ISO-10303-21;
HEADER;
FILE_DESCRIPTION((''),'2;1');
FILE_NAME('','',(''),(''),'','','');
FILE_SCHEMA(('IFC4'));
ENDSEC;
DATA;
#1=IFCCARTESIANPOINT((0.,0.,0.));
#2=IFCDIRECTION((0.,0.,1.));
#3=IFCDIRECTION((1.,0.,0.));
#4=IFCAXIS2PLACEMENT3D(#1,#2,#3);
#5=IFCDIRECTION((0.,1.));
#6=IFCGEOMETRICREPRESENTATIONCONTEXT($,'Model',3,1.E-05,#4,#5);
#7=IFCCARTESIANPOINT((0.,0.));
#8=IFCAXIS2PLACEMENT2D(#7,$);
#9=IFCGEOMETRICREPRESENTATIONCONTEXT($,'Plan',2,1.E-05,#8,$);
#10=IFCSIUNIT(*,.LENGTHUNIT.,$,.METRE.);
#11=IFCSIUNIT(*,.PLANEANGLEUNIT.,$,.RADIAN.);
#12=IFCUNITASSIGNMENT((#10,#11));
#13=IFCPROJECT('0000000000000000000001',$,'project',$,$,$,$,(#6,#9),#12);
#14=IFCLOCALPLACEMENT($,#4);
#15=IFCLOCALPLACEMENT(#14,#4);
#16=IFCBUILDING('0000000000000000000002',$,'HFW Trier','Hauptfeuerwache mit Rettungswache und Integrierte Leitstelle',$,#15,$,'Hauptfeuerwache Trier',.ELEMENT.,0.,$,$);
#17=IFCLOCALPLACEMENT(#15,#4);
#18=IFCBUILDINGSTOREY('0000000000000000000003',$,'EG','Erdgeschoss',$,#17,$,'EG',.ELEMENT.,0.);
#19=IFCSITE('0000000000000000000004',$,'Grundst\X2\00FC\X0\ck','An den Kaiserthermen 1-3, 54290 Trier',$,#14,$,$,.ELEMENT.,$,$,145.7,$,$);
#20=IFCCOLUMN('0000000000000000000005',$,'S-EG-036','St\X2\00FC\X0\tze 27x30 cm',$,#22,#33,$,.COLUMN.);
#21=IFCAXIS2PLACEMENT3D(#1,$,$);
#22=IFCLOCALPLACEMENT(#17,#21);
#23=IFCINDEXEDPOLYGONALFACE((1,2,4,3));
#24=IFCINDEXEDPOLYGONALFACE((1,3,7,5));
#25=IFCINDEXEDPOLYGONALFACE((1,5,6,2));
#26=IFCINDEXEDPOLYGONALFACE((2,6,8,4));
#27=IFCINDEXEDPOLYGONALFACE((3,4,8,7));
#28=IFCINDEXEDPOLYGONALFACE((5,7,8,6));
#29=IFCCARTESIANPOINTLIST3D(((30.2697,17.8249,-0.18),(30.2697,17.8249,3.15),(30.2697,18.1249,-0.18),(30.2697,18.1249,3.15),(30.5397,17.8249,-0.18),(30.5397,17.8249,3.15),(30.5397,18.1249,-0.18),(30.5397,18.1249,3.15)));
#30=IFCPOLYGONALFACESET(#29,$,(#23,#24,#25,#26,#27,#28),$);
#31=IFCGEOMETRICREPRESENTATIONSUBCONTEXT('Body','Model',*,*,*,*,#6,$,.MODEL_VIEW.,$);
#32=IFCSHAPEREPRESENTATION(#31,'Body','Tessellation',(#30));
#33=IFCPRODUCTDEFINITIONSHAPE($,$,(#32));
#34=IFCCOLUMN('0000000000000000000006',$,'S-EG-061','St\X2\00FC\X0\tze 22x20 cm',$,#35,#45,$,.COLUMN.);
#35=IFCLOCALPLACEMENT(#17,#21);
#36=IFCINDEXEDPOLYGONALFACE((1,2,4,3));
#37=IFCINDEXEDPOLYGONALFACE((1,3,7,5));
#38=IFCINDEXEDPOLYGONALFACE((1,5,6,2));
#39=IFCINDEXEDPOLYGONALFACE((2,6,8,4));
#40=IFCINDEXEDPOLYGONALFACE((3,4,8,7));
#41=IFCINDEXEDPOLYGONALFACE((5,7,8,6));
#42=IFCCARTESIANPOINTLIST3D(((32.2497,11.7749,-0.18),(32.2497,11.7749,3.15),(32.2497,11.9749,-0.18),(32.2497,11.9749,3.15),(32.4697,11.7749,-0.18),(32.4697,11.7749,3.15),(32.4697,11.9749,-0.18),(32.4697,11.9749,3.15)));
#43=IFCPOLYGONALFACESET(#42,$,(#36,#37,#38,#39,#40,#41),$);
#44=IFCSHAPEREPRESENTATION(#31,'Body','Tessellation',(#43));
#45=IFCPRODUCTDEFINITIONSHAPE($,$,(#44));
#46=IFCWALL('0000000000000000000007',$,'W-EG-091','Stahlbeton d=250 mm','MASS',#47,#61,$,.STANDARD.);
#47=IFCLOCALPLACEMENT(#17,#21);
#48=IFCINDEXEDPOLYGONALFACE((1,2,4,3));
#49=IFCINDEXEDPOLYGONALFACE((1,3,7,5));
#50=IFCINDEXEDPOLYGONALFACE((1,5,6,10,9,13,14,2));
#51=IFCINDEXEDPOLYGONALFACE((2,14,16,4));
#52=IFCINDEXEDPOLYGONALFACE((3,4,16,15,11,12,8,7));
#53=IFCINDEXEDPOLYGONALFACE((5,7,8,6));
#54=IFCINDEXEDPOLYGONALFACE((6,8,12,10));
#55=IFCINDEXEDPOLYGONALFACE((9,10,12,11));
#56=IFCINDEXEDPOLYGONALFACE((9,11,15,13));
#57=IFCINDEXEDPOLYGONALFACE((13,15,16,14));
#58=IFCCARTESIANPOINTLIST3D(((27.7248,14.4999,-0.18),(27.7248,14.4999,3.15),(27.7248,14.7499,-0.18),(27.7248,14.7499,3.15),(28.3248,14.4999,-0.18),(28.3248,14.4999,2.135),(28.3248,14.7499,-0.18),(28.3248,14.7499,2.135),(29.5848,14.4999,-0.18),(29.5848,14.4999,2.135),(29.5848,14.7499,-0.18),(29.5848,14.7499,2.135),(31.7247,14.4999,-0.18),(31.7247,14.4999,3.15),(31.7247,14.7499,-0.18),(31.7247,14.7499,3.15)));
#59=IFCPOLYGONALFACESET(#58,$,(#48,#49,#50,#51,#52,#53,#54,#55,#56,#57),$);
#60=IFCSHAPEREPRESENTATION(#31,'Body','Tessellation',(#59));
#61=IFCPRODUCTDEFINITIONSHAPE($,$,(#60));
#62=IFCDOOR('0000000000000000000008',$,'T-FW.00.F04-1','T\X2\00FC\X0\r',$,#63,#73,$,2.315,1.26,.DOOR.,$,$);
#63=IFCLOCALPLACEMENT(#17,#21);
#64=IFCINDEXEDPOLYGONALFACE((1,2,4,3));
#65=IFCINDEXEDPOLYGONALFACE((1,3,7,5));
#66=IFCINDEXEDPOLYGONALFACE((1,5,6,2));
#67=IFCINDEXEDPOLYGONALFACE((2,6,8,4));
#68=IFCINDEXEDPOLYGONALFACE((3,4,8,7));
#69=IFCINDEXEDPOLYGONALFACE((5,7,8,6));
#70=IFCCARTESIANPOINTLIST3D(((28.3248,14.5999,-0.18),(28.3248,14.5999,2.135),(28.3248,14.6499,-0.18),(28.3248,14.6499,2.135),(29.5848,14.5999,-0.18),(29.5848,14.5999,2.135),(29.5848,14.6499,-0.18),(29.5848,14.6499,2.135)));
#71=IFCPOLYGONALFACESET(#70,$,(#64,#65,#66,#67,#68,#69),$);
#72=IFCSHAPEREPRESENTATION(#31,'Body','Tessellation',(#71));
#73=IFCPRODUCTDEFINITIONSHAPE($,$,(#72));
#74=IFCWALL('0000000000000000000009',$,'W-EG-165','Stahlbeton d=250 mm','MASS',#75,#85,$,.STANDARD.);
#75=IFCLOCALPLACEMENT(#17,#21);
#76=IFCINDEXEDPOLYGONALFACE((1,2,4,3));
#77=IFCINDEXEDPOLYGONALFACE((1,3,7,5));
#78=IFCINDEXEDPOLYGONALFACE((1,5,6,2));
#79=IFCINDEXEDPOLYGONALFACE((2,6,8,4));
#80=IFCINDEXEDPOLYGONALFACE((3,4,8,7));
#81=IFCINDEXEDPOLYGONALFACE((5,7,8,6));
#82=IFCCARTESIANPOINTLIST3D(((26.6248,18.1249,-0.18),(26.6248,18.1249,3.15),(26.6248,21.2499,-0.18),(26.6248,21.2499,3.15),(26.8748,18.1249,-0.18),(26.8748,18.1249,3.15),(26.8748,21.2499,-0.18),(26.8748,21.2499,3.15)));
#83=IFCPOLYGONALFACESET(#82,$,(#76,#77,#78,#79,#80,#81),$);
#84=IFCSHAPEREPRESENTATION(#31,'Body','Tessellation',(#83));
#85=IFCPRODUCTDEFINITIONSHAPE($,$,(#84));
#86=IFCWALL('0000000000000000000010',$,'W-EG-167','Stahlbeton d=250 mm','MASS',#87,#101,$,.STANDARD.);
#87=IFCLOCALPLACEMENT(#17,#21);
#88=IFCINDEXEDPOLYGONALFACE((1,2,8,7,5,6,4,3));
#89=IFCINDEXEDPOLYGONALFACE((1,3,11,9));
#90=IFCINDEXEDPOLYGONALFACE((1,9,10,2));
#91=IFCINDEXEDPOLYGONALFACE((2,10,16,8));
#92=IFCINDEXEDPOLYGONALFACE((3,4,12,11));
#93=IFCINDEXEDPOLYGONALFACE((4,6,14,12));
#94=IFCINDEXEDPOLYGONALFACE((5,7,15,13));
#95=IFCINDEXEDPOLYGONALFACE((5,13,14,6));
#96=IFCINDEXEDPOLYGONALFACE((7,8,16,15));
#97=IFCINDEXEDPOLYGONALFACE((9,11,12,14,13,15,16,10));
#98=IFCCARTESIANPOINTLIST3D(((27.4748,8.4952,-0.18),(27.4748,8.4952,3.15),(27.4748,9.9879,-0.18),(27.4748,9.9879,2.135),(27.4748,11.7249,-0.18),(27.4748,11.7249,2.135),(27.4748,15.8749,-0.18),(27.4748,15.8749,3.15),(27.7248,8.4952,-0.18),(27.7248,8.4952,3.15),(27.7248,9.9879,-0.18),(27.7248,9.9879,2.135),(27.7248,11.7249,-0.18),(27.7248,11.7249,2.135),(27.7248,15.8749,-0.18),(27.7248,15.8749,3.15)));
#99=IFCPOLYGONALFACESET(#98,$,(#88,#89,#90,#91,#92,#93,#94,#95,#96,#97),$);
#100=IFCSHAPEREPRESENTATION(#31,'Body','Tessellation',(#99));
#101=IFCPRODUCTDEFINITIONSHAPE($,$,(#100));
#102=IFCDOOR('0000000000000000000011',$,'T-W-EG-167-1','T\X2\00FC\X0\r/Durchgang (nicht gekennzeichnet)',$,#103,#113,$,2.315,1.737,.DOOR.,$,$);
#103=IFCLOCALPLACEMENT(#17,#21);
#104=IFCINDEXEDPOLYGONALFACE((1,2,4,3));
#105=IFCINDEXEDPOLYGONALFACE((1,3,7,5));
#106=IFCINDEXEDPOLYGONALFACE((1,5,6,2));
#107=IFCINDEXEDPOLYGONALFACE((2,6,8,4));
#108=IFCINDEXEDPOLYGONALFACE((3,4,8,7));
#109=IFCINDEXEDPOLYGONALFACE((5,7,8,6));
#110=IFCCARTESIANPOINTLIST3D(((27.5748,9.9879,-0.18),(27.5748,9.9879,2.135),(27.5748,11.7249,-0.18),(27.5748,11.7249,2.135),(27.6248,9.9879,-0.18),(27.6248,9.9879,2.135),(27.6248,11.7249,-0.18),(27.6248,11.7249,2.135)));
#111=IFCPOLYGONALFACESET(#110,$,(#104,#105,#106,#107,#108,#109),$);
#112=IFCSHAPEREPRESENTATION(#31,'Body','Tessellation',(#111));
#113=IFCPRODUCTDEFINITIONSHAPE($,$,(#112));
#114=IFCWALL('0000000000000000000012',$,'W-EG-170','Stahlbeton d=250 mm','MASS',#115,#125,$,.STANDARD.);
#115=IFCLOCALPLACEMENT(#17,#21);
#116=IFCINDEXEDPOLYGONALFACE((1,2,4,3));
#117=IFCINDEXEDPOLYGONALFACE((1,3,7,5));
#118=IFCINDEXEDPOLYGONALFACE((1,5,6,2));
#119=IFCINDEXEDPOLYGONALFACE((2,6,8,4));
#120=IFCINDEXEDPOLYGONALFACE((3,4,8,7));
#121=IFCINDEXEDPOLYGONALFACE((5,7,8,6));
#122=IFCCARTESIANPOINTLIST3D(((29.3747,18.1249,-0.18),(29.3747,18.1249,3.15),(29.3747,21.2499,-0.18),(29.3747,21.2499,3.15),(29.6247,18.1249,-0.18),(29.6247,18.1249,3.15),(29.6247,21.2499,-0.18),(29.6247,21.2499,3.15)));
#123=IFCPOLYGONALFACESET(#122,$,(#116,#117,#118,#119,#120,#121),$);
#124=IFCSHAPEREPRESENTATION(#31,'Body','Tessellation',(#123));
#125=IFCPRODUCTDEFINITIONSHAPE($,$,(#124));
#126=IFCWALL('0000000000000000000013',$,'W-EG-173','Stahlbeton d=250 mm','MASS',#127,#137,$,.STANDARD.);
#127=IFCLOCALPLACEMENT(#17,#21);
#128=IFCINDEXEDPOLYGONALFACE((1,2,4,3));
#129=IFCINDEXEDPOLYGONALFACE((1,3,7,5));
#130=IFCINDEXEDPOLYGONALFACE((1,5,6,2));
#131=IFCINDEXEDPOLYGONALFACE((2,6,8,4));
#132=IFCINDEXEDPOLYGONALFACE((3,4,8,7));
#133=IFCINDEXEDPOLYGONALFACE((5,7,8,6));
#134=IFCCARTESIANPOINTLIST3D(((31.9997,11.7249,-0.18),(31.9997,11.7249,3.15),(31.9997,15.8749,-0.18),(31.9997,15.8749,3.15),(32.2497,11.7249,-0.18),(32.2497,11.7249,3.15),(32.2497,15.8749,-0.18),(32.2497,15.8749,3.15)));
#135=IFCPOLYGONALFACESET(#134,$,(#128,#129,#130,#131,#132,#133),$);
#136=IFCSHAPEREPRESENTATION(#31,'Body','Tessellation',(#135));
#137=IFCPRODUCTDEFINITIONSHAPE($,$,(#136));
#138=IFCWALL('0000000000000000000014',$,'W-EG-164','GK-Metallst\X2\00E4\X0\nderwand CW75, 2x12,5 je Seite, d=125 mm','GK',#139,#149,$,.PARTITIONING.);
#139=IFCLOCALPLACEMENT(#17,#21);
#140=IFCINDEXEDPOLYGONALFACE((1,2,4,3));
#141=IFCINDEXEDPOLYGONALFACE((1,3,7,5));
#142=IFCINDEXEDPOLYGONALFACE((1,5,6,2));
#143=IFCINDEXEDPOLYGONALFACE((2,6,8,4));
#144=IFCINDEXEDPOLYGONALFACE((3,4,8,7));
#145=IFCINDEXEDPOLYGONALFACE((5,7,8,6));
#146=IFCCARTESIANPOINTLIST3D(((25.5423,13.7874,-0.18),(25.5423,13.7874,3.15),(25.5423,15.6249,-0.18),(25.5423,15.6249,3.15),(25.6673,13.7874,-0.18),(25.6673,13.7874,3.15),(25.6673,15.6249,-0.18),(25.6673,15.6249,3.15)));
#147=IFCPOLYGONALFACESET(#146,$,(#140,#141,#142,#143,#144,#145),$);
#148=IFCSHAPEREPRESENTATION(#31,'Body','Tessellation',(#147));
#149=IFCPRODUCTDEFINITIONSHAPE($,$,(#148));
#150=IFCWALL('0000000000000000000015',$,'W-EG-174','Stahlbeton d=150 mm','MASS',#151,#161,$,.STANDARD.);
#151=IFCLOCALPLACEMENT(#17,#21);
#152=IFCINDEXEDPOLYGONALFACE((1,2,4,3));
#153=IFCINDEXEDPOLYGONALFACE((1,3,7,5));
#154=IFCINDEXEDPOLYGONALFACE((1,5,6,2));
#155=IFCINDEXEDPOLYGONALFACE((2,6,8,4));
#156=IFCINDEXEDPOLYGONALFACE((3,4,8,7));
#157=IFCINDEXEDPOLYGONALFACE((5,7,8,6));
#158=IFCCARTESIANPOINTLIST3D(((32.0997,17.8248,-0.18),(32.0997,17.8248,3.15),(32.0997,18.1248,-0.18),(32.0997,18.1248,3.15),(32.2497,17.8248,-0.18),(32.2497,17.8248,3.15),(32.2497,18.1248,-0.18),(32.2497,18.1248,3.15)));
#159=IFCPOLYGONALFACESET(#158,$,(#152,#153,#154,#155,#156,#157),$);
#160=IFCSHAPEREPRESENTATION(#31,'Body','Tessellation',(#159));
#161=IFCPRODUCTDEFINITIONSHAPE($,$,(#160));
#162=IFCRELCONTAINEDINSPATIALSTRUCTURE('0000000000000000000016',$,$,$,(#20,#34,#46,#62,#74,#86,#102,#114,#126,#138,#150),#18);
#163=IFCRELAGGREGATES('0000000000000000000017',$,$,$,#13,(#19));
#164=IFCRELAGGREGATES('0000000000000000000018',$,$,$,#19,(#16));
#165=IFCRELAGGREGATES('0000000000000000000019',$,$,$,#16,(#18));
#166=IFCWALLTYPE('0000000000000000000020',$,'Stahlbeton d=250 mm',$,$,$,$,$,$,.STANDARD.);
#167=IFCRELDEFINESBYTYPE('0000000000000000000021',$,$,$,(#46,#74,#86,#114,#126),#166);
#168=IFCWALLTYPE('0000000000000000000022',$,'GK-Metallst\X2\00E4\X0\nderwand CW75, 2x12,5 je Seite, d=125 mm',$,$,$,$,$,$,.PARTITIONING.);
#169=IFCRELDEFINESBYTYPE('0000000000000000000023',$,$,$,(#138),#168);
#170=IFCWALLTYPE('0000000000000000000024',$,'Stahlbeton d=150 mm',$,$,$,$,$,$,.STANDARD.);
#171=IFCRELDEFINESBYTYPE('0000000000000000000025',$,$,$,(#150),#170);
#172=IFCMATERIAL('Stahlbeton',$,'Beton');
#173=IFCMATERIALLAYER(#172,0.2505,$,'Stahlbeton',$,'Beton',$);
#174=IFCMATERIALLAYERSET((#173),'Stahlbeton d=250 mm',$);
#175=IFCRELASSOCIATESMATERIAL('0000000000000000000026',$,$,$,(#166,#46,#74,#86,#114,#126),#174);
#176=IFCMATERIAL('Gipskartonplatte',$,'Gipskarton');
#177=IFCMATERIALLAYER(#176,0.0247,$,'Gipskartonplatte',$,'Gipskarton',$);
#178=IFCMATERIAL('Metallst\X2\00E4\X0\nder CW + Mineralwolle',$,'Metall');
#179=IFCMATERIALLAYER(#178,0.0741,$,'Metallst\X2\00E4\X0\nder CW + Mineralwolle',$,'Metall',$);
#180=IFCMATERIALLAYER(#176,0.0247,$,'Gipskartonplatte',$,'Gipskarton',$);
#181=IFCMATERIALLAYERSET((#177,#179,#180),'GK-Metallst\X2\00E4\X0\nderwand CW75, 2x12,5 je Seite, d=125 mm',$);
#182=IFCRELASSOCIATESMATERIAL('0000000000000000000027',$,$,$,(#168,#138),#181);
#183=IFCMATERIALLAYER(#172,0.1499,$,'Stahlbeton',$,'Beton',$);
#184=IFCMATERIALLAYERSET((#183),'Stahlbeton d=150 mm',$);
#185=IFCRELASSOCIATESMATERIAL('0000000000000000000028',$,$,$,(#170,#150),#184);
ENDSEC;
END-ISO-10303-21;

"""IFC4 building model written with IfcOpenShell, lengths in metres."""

from ifc_helpers import new_model, si_unit, direction, frame, frame_2d, origin_with_axes, origin_2d, place, context, subcontext, project, spatial, rectangle, extrude, material, layer, layer_set, layer_usage, type_object, element, fill, save


model = new_model("IFC4")

# Units and contexts
model_context = context("Model", 3, precision=1e-05, world=origin_with_axes(), true_north=direction((0.0, 1.0)))
plan_context = context("Plan", 2, precision=1e-05, world=origin_2d())
body_context = subcontext(model_context, "Body", "Model", "MODEL_VIEW")
ifc_project = project(units=[si_unit("LENGTHUNIT", "METRE"), si_unit("PLANEANGLEUNIT", "RADIAN")], contexts=[model_context, plan_context])

# Site, building, storey
site_placement = place(None, origin_with_axes())
site = spatial("IfcSite", under=ifc_project, at=site_placement, Name="Grundstück", Description="An den Kaiserthermen 1-3, 54290 Trier", CompositionType="ELEMENT", RefElevation=145.7)
building_placement = place(site_placement, origin_with_axes())
building = spatial("IfcBuilding", under=site, at=building_placement, Name="HFW Trier", Description="Hauptfeuerwache mit Rettungswache und Integrierte Leitstelle", LongName="Hauptfeuerwache Trier", CompositionType="ELEMENT", ElevationOfRefHeight=0.0)
storey_placement = place(building_placement, origin_with_axes())
storey = spatial("IfcBuildingStorey", under=building, at=storey_placement, Name="EG", Description="Erdgeschoss", LongName="EG", CompositionType="ELEMENT", Elevation=0.0)

# Columns
column_1_placement = place(storey_placement, frame((30.2697, 17.9749, -0.18), z_axis=(0.0, 0.0, 1.0), x_axis=(1.0, 0.0, 0.0)))
element("IfcColumn", 1, at=column_1_placement, inside=storey, Name="S-EG-036", Description="Stütze 27x30 cm", PredefinedType="COLUMN", context=body_context, shape_type="SweptSolid", body=[
    extrude(rectangle(XDim=0.27, YDim=0.3, at=frame_2d((0.135, 0.0))), origin_with_axes(), (0.0, 0.0, 1.0), 3.33),
])
column_2_placement = place(storey_placement, frame((32.2497, 11.8749, -0.18), z_axis=(0.0, 0.0, 1.0), x_axis=(1.0, 0.0, 0.0)))
element("IfcColumn", 2, at=column_2_placement, inside=storey, Name="S-EG-061", Description="Stütze 22x20 cm", PredefinedType="COLUMN", context=body_context, shape_type="SweptSolid", body=[
    extrude(rectangle(XDim=0.22, YDim=0.2, at=frame_2d((0.11, 0.0))), origin_with_axes(), (0.0, 0.0, 1.0), 3.33),
])

# Wall, opening, door
ifc_material_1 = material(Name="Stahlbeton", Category="Beton")
ifc_layer_1 = layer(ifc_material_1, 0.2505, Name="Stahlbeton", Category="Beton")
ifc_layer_set_1 = layer_set([ifc_layer_1], Name="Stahlbeton d=250 mm")
ifc_layer_usage_1 = layer_usage(ifc_layer_set_1, "AXIS2", "POSITIVE", -0.125)
wall_type_1 = type_object("IfcWallType", Name="Stahlbeton d=250 mm", PredefinedType="STANDARD", material=ifc_layer_set_1)
wall_1_placement = place(storey_placement, frame((27.7248, 14.6249, -0.18), z_axis=(0.0, 0.0, 1.0), x_axis=(1.0, 0.0, 0.0)))
wall_1 = element("IfcWall", 3, at=wall_1_placement, inside=storey, type_object=wall_type_1, material=ifc_layer_usage_1, Name="W-EG-091", Description="Stahlbeton d=250 mm", ObjectType="MASS", PredefinedType="STANDARD", context=body_context, shape_type="SweptSolid", body=[
    extrude(rectangle(XDim=3.9999, YDim=0.25, at=frame_2d((2.0, 0.0))), origin_with_axes(), (0.0, 0.0, 1.0), 3.33),
])
opening_1_placement = place(wall_1_placement, frame((0.6, 0.0, 0.0), z_axis=(0.0, 0.0, 1.0), x_axis=(1.0, 0.0, 0.0)))
opening_1 = element("IfcOpeningElement", 4, at=opening_1_placement, cuts=wall_1, PredefinedType="OPENING", context=body_context, shape_type="SweptSolid", body=[
    extrude(rectangle(XDim=1.26, YDim=0.35, at=frame_2d((0.63, 0.0))), origin_with_axes(), (0.0, 0.0, 1.0), 2.315),
])
door_1_placement = place(wall_1_placement, frame((0.6, 0.0, 0.0), z_axis=(0.0, 0.0, 1.0), x_axis=(1.0, 0.0, 0.0)))
door_1 = element("IfcDoor", 5, at=door_1_placement, inside=storey, Name="T-FW.00.F04-1", Description="Tür", OverallHeight=2.315, OverallWidth=1.26, PredefinedType="DOOR", context=body_context, shape_type="SweptSolid", body=[
    extrude(rectangle(XDim=1.26, YDim=0.05, at=frame_2d((0.63, 0.0))), origin_with_axes(), (0.0, 0.0, 1.0), 2.315),
])
fill(opening_1, door_1)

# Wall
ifc_layer_usage_2 = layer_usage(ifc_layer_set_1, "AXIS2", "POSITIVE", -0.125)
wall_2_placement = place(storey_placement, frame((26.7498, 21.2499, -0.18), z_axis=(0.0, 0.0, 1.0), x_axis=(0.0, -1.0, 0.0)))
element("IfcWall", 6, at=wall_2_placement, inside=storey, type_object=wall_type_1, material=ifc_layer_usage_2, Name="W-EG-165", Description="Stahlbeton d=250 mm", ObjectType="MASS", PredefinedType="STANDARD", context=body_context, shape_type="SweptSolid", body=[
    extrude(rectangle(XDim=3.125, YDim=0.25, at=frame_2d((1.5625, 0.0))), origin_with_axes(), (0.0, 0.0, 1.0), 3.33),
])

# Wall, opening, door
ifc_layer_usage_3 = layer_usage(ifc_layer_set_1, "AXIS2", "POSITIVE", -0.125)
wall_3_placement = place(storey_placement, frame((27.5998, 15.8749, -0.18), z_axis=(0.0, 0.0, 1.0), x_axis=(0.0, -1.0, 0.0)))
wall_3 = element("IfcWall", 7, at=wall_3_placement, inside=storey, type_object=wall_type_1, material=ifc_layer_usage_3, Name="W-EG-167", Description="Stahlbeton d=250 mm", ObjectType="MASS", PredefinedType="STANDARD", context=body_context, shape_type="SweptSolid", body=[
    extrude(rectangle(XDim=7.3797, YDim=0.25, at=frame_2d((3.6898, 0.0))), origin_with_axes(), (0.0, 0.0, 1.0), 3.33),
])
opening_2_placement = place(wall_3_placement, frame((4.15, 0.0, 0.0), z_axis=(0.0, 0.0, 1.0), x_axis=(1.0, 0.0, 0.0)))
opening_2 = element("IfcOpeningElement", 8, at=opening_2_placement, cuts=wall_3, PredefinedType="OPENING", context=body_context, shape_type="SweptSolid", body=[
    extrude(rectangle(XDim=1.737, YDim=0.35, at=frame_2d((0.8685, 0.0))), origin_with_axes(), (0.0, 0.0, 1.0), 2.315),
])
door_2_placement = place(wall_3_placement, frame((4.15, 0.0, 0.0), z_axis=(0.0, 0.0, 1.0), x_axis=(1.0, 0.0, 0.0)))
door_2 = element("IfcDoor", 9, at=door_2_placement, inside=storey, Name="T-W-EG-167-1", Description="Tür/Durchgang (nicht gekennzeichnet)", OverallHeight=2.315, OverallWidth=1.737, PredefinedType="DOOR", context=body_context, shape_type="SweptSolid", body=[
    extrude(rectangle(XDim=1.737, YDim=0.05, at=frame_2d((0.8685, 0.0))), origin_with_axes(), (0.0, 0.0, 1.0), 2.315),
])
fill(opening_2, door_2)

# Walls
ifc_layer_usage_4 = layer_usage(ifc_layer_set_1, "AXIS2", "POSITIVE", -0.125)
wall_4_placement = place(storey_placement, frame((29.4997, 21.2499, -0.18), z_axis=(0.0, 0.0, 1.0), x_axis=(0.0, -1.0, 0.0)))
element("IfcWall", 10, at=wall_4_placement, inside=storey, type_object=wall_type_1, material=ifc_layer_usage_4, Name="W-EG-170", Description="Stahlbeton d=250 mm", ObjectType="MASS", PredefinedType="STANDARD", context=body_context, shape_type="SweptSolid", body=[
    extrude(rectangle(XDim=3.125, YDim=0.25, at=frame_2d((1.5625, 0.0))), origin_with_axes(), (0.0, 0.0, 1.0), 3.33),
])
ifc_layer_usage_5 = layer_usage(ifc_layer_set_1, "AXIS2", "POSITIVE", -0.125)
wall_5_placement = place(storey_placement, frame((32.1247, 15.8749, -0.18), z_axis=(0.0, 0.0, 1.0), x_axis=(0.0, -1.0, 0.0)))
element("IfcWall", 11, at=wall_5_placement, inside=storey, type_object=wall_type_1, material=ifc_layer_usage_5, Name="W-EG-173", Description="Stahlbeton d=250 mm", ObjectType="MASS", PredefinedType="STANDARD", context=body_context, shape_type="SweptSolid", body=[
    extrude(rectangle(XDim=4.15, YDim=0.25, at=frame_2d((2.075, 0.0))), origin_with_axes(), (0.0, 0.0, 1.0), 3.33),
])
ifc_material_2 = material(Name="Gipskartonplatte", Category="Gipskarton")
ifc_layer_2 = layer(ifc_material_2, 0.0247, Name="Gipskartonplatte", Category="Gipskarton")
ifc_material_3 = material(Name="Metallständer CW + Mineralwolle", Category="Metall")
ifc_layer_3 = layer(ifc_material_3, 0.0741, Name="Metallständer CW + Mineralwolle", Category="Metall")
ifc_layer_4 = layer(ifc_material_2, 0.0247, Name="Gipskartonplatte", Category="Gipskarton")
ifc_layer_set_2 = layer_set([ifc_layer_2, ifc_layer_3, ifc_layer_4], Name="GK-Metallständerwand CW75, 2x12,5 je Seite, d=125 mm")
ifc_layer_usage_6 = layer_usage(ifc_layer_set_2, "AXIS2", "POSITIVE", -0.0625)
wall_type_2 = type_object("IfcWallType", Name="GK-Metallständerwand CW75, 2x12,5 je Seite, d=125 mm", PredefinedType="PARTITIONING", material=ifc_layer_set_2)
wall_6_placement = place(storey_placement, frame((25.6048, 15.6249, -0.18), z_axis=(0.0, 0.0, 1.0), x_axis=(0.0, -1.0, 0.0)))
element("IfcWall", 12, at=wall_6_placement, inside=storey, type_object=wall_type_2, material=ifc_layer_usage_6, Name="W-EG-164", Description="GK-Metallständerwand CW75, 2x12,5 je Seite, d=125 mm", ObjectType="GK", PredefinedType="PARTITIONING", context=body_context, shape_type="SweptSolid", body=[
    extrude(rectangle(XDim=1.8375, YDim=0.125, at=frame_2d((0.9188, 0.0))), origin_with_axes(), (0.0, 0.0, 1.0), 3.33),
])
ifc_layer_5 = layer(ifc_material_1, 0.1499, Name="Stahlbeton", Category="Beton")
ifc_layer_set_3 = layer_set([ifc_layer_5], Name="Stahlbeton d=150 mm")
ifc_layer_usage_7 = layer_usage(ifc_layer_set_3, "AXIS2", "POSITIVE", -0.075)
wall_type_3 = type_object("IfcWallType", Name="Stahlbeton d=150 mm", PredefinedType="STANDARD", material=ifc_layer_set_3)
wall_7_placement = place(storey_placement, frame((32.1747, 18.1248, -0.18), z_axis=(0.0, 0.0, 1.0), x_axis=(0.0, -1.0, 0.0)))
element("IfcWall", 13, at=wall_7_placement, inside=storey, type_object=wall_type_3, material=ifc_layer_usage_7, Name="W-EG-174", Description="Stahlbeton d=150 mm", ObjectType="MASS", PredefinedType="STANDARD", context=body_context, shape_type="SweptSolid", body=[
    extrude(rectangle(XDim=0.3, YDim=0.15, at=frame_2d((0.15, 0.0))), origin_with_axes(), (0.0, 0.0, 1.0), 3.33),
])

save(model, "model.ifc")
